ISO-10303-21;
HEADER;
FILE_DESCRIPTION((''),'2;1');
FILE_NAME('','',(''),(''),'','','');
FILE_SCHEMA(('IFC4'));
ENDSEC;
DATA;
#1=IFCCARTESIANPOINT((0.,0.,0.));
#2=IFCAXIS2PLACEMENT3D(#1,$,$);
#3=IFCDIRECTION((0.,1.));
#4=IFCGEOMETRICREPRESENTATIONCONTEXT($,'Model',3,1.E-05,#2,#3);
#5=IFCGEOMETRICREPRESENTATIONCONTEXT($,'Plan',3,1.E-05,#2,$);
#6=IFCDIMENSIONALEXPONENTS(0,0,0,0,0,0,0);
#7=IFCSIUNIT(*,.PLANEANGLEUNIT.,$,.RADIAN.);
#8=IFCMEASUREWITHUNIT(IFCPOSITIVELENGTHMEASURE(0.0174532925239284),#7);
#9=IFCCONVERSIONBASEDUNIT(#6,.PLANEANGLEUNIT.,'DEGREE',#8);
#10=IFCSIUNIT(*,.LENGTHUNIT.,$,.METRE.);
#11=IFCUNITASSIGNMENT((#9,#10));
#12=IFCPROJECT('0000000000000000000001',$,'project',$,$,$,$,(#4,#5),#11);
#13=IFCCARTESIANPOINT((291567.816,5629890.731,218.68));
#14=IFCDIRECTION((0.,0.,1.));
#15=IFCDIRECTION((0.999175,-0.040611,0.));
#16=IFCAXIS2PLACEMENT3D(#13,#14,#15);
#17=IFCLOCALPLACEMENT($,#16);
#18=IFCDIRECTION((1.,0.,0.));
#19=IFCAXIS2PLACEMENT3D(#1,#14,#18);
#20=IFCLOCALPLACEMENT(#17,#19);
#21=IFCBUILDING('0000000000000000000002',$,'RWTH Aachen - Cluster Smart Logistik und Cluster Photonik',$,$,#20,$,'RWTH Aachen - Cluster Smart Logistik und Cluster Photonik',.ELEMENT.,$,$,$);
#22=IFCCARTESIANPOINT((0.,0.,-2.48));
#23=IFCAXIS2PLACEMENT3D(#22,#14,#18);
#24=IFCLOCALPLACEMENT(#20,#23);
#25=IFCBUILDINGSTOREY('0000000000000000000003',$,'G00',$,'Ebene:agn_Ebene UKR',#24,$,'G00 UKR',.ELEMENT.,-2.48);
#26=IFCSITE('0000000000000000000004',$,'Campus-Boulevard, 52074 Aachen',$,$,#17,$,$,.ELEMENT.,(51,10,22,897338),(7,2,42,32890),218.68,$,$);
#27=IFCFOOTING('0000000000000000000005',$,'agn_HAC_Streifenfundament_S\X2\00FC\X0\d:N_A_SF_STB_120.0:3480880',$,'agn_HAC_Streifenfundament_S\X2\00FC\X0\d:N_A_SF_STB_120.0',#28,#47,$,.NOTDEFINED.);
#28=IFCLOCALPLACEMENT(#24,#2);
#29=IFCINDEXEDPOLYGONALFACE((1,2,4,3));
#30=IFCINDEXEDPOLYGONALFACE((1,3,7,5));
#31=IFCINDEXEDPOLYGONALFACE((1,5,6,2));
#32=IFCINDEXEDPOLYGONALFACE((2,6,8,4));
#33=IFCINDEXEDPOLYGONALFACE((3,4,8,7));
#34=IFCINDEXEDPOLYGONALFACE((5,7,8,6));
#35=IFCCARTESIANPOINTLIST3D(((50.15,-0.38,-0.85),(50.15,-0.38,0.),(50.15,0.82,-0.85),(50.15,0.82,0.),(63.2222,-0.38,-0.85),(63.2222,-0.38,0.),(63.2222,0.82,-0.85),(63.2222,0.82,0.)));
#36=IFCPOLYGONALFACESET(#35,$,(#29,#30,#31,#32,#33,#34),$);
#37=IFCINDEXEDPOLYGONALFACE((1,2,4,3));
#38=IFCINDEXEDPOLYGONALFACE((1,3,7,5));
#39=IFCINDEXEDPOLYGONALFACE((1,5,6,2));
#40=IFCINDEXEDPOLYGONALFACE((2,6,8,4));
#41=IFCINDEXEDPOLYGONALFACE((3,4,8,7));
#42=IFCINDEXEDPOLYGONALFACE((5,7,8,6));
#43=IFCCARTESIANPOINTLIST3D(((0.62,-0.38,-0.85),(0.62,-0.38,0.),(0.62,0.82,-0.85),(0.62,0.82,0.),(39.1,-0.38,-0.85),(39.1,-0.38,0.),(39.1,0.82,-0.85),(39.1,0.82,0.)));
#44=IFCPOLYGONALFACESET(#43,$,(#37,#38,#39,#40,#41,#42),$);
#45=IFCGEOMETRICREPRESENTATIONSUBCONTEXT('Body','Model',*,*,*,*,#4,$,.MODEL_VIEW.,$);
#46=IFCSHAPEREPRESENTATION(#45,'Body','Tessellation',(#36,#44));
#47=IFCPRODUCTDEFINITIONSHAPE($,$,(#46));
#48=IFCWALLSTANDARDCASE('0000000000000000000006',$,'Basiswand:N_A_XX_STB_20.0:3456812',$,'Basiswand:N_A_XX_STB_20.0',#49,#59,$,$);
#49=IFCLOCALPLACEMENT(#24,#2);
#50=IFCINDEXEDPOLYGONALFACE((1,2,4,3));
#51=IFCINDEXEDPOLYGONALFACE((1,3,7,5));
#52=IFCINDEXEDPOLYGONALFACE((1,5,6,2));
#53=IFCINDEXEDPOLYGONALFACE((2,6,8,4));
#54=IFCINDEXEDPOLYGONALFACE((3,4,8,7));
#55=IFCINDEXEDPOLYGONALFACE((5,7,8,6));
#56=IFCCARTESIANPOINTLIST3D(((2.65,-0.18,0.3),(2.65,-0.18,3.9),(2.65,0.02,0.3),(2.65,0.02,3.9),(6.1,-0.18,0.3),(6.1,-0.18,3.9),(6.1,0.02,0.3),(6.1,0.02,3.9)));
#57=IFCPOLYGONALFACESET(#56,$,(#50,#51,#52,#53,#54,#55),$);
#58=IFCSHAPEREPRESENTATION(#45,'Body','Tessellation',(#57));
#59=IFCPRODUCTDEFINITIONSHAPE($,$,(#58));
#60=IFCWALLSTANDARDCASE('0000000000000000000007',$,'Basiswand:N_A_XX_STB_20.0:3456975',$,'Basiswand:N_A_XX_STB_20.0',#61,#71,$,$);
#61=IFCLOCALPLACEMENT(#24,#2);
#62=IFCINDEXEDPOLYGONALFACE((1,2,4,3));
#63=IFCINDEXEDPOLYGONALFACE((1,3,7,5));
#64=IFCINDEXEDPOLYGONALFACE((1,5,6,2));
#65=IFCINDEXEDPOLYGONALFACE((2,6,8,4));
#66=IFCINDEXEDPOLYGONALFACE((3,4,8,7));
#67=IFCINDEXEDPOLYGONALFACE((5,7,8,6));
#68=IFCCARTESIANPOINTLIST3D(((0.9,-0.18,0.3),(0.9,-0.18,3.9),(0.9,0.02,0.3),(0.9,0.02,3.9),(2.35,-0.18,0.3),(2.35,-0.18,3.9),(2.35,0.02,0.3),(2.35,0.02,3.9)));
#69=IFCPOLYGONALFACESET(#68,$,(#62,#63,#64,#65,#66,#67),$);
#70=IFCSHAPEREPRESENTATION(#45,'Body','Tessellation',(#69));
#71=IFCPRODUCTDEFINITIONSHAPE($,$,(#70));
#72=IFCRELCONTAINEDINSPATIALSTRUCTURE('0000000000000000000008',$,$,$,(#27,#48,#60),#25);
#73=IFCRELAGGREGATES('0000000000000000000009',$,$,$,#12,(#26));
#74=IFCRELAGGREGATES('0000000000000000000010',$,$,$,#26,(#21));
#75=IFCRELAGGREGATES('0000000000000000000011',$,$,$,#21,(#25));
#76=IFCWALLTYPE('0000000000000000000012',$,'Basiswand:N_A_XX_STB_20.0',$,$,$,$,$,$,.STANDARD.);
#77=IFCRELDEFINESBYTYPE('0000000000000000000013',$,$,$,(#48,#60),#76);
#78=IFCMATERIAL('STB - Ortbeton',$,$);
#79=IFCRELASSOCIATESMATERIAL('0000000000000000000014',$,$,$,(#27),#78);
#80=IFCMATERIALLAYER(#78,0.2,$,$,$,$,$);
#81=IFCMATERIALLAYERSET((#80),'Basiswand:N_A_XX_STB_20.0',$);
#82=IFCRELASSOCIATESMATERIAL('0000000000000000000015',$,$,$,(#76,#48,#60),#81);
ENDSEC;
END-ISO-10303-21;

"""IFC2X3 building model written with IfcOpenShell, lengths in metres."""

from ifc_helpers import new_model, entity, si_unit, converted_unit, direction, frame, frame_2d, origin, origin_with_axes, origin_2d_with_axis, place, context, subcontext, project, spatial, rectangle, extrude, source, transform, mapped, material, layer, layer_set, layer_usage, type_object, element, save


model = new_model("IFC2X3")

# Units and contexts
model_context = context("Model", 3, precision=1e-05, world=origin(), true_north=direction((0.0, 1.0)))
plan_context = context("Plan", 3, precision=1e-05, world=origin())
body_context = subcontext(model_context, "Body", "Model", "MODEL_VIEW")
ifc_project = project(units=[converted_unit("PLANEANGLEUNIT", "DEGREE", entity("IfcPositiveLengthMeasure", 0.0174532925239284), si_unit("PLANEANGLEUNIT", "RADIAN"), dimensions=[0, 0, 0, 0, 0, 0, 0]), si_unit("LENGTHUNIT", "METRE")], contexts=[model_context, plan_context])

# Site, building, storey
site_placement = place(None, frame((291567.816, 5629890.731, 218.68), z_axis=(0.0, 0.0, 1.0), x_axis=(0.999175, -0.040611, 0.0)))
site = spatial("IfcSite", under=ifc_project, at=site_placement, Name="Campus-Boulevard, 52074 Aachen", CompositionType="ELEMENT", RefLatitude=(51, 10, 22, 897338), RefLongitude=(7, 2, 42, 32890), RefElevation=218.68)
building_placement = place(site_placement, origin_with_axes())
building = spatial("IfcBuilding", under=site, at=building_placement, Name="RWTH Aachen - Cluster Smart Logistik und Cluster Photonik", LongName="RWTH Aachen - Cluster Smart Logistik und Cluster Photonik", CompositionType="ELEMENT")
storey_placement = place(building_placement, frame((0.0, 0.0, -2.48), z_axis=(0.0, 0.0, 1.0), x_axis=(1.0, 0.0, 0.0)))
storey = spatial("IfcBuildingStorey", under=building, at=storey_placement, Name="G00", ObjectType="Ebene:agn_Ebene UKR", LongName="G00 UKR", CompositionType="ELEMENT", Elevation=-2.48)

# Footing
ifc_material = material(Name="STB - Ortbeton")
shared_shape_1 = source(origin(), body_context, "Body", "SweptSolid", [
    extrude(rectangle(XDim=1.2, YDim=13.0722, at=frame_2d((0.0, 0.0), x_axis=(1.0, 0.0))), frame((56.0661, 0.6, 0.0), z_axis=(0.0, 0.0, 1.0), x_axis=(0.0, -1.0, 0.0)), (0.0, 0.0, 1.0), 0.85),
    extrude(rectangle(XDim=1.2, YDim=38.48, at=origin_2d_with_axis()), frame((19.24, 0.6, 0.0), z_axis=(0.0, 0.0, 1.0), x_axis=(0.0, -1.0, 0.0)), (0.0, 0.0, 1.0), 0.85),
])
footing_placement = place(storey_placement, frame((0.62, -0.38, -0.85), z_axis=(0.0, 0.0, 1.0), x_axis=(1.0, 0.0, 0.0)))
element("IfcFooting", 1, at=footing_placement, inside=storey, material=ifc_material, Name="agn_HAC_Streifenfundament_Süd:N_A_SF_STB_120.0:3480880", ObjectType="agn_HAC_Streifenfundament_Süd:N_A_SF_STB_120.0", PredefinedType="NOTDEFINED", context=body_context, shape_type="MappedRepresentation", body=[
    mapped(shared_shape_1, transform((0.0, 0.0, 0.0), scale=1.0)),
])

# Walls
ifc_layer = layer(ifc_material, 0.2)
ifc_layer_set = layer_set([ifc_layer], Name="Basiswand:N_A_XX_STB_20.0")
ifc_layer_usage_1 = layer_usage(ifc_layer_set, "AXIS2", "NEGATIVE", 0.1)
wall_type = type_object("IfcWallType", Name="Basiswand:N_A_XX_STB_20.0", PredefinedType="STANDARD", material=ifc_layer_set)
wall_1_placement = place(storey_placement, frame((6.1, -0.08, 0.3), z_axis=(0.0, 0.0, 1.0), x_axis=(-1.0, 0.0, 0.0)))
element("IfcWallStandardCase", 2, at=wall_1_placement, inside=storey, type_object=wall_type, material=ifc_layer_usage_1, Name="Basiswand:N_A_XX_STB_20.0:3456812", ObjectType="Basiswand:N_A_XX_STB_20.0", context=body_context, shape_type="SweptSolid", body=[
    extrude(rectangle(XDim=3.45, YDim=0.2, at=frame_2d((1.725, 0.0), x_axis=(-1.0, 0.0))), origin(), (0.0, 0.0, 1.0), 3.6),
])
ifc_layer_usage_2 = layer_usage(ifc_layer_set, "AXIS2", "NEGATIVE", 0.1)
wall_2_placement = place(storey_placement, frame((2.35, -0.08, 0.3), z_axis=(0.0, 0.0, 1.0), x_axis=(-1.0, 0.0, 0.0)))
element("IfcWallStandardCase", 3, at=wall_2_placement, inside=storey, type_object=wall_type, material=ifc_layer_usage_2, Name="Basiswand:N_A_XX_STB_20.0:3456975", ObjectType="Basiswand:N_A_XX_STB_20.0", context=body_context, shape_type="SweptSolid", body=[
    extrude(rectangle(XDim=1.45, YDim=0.2, at=frame_2d((0.725, 0.0), x_axis=(-1.0, 0.0))), origin(), (0.0, 0.0, 1.0), 3.6),
])

save(model, "model.ifc")
